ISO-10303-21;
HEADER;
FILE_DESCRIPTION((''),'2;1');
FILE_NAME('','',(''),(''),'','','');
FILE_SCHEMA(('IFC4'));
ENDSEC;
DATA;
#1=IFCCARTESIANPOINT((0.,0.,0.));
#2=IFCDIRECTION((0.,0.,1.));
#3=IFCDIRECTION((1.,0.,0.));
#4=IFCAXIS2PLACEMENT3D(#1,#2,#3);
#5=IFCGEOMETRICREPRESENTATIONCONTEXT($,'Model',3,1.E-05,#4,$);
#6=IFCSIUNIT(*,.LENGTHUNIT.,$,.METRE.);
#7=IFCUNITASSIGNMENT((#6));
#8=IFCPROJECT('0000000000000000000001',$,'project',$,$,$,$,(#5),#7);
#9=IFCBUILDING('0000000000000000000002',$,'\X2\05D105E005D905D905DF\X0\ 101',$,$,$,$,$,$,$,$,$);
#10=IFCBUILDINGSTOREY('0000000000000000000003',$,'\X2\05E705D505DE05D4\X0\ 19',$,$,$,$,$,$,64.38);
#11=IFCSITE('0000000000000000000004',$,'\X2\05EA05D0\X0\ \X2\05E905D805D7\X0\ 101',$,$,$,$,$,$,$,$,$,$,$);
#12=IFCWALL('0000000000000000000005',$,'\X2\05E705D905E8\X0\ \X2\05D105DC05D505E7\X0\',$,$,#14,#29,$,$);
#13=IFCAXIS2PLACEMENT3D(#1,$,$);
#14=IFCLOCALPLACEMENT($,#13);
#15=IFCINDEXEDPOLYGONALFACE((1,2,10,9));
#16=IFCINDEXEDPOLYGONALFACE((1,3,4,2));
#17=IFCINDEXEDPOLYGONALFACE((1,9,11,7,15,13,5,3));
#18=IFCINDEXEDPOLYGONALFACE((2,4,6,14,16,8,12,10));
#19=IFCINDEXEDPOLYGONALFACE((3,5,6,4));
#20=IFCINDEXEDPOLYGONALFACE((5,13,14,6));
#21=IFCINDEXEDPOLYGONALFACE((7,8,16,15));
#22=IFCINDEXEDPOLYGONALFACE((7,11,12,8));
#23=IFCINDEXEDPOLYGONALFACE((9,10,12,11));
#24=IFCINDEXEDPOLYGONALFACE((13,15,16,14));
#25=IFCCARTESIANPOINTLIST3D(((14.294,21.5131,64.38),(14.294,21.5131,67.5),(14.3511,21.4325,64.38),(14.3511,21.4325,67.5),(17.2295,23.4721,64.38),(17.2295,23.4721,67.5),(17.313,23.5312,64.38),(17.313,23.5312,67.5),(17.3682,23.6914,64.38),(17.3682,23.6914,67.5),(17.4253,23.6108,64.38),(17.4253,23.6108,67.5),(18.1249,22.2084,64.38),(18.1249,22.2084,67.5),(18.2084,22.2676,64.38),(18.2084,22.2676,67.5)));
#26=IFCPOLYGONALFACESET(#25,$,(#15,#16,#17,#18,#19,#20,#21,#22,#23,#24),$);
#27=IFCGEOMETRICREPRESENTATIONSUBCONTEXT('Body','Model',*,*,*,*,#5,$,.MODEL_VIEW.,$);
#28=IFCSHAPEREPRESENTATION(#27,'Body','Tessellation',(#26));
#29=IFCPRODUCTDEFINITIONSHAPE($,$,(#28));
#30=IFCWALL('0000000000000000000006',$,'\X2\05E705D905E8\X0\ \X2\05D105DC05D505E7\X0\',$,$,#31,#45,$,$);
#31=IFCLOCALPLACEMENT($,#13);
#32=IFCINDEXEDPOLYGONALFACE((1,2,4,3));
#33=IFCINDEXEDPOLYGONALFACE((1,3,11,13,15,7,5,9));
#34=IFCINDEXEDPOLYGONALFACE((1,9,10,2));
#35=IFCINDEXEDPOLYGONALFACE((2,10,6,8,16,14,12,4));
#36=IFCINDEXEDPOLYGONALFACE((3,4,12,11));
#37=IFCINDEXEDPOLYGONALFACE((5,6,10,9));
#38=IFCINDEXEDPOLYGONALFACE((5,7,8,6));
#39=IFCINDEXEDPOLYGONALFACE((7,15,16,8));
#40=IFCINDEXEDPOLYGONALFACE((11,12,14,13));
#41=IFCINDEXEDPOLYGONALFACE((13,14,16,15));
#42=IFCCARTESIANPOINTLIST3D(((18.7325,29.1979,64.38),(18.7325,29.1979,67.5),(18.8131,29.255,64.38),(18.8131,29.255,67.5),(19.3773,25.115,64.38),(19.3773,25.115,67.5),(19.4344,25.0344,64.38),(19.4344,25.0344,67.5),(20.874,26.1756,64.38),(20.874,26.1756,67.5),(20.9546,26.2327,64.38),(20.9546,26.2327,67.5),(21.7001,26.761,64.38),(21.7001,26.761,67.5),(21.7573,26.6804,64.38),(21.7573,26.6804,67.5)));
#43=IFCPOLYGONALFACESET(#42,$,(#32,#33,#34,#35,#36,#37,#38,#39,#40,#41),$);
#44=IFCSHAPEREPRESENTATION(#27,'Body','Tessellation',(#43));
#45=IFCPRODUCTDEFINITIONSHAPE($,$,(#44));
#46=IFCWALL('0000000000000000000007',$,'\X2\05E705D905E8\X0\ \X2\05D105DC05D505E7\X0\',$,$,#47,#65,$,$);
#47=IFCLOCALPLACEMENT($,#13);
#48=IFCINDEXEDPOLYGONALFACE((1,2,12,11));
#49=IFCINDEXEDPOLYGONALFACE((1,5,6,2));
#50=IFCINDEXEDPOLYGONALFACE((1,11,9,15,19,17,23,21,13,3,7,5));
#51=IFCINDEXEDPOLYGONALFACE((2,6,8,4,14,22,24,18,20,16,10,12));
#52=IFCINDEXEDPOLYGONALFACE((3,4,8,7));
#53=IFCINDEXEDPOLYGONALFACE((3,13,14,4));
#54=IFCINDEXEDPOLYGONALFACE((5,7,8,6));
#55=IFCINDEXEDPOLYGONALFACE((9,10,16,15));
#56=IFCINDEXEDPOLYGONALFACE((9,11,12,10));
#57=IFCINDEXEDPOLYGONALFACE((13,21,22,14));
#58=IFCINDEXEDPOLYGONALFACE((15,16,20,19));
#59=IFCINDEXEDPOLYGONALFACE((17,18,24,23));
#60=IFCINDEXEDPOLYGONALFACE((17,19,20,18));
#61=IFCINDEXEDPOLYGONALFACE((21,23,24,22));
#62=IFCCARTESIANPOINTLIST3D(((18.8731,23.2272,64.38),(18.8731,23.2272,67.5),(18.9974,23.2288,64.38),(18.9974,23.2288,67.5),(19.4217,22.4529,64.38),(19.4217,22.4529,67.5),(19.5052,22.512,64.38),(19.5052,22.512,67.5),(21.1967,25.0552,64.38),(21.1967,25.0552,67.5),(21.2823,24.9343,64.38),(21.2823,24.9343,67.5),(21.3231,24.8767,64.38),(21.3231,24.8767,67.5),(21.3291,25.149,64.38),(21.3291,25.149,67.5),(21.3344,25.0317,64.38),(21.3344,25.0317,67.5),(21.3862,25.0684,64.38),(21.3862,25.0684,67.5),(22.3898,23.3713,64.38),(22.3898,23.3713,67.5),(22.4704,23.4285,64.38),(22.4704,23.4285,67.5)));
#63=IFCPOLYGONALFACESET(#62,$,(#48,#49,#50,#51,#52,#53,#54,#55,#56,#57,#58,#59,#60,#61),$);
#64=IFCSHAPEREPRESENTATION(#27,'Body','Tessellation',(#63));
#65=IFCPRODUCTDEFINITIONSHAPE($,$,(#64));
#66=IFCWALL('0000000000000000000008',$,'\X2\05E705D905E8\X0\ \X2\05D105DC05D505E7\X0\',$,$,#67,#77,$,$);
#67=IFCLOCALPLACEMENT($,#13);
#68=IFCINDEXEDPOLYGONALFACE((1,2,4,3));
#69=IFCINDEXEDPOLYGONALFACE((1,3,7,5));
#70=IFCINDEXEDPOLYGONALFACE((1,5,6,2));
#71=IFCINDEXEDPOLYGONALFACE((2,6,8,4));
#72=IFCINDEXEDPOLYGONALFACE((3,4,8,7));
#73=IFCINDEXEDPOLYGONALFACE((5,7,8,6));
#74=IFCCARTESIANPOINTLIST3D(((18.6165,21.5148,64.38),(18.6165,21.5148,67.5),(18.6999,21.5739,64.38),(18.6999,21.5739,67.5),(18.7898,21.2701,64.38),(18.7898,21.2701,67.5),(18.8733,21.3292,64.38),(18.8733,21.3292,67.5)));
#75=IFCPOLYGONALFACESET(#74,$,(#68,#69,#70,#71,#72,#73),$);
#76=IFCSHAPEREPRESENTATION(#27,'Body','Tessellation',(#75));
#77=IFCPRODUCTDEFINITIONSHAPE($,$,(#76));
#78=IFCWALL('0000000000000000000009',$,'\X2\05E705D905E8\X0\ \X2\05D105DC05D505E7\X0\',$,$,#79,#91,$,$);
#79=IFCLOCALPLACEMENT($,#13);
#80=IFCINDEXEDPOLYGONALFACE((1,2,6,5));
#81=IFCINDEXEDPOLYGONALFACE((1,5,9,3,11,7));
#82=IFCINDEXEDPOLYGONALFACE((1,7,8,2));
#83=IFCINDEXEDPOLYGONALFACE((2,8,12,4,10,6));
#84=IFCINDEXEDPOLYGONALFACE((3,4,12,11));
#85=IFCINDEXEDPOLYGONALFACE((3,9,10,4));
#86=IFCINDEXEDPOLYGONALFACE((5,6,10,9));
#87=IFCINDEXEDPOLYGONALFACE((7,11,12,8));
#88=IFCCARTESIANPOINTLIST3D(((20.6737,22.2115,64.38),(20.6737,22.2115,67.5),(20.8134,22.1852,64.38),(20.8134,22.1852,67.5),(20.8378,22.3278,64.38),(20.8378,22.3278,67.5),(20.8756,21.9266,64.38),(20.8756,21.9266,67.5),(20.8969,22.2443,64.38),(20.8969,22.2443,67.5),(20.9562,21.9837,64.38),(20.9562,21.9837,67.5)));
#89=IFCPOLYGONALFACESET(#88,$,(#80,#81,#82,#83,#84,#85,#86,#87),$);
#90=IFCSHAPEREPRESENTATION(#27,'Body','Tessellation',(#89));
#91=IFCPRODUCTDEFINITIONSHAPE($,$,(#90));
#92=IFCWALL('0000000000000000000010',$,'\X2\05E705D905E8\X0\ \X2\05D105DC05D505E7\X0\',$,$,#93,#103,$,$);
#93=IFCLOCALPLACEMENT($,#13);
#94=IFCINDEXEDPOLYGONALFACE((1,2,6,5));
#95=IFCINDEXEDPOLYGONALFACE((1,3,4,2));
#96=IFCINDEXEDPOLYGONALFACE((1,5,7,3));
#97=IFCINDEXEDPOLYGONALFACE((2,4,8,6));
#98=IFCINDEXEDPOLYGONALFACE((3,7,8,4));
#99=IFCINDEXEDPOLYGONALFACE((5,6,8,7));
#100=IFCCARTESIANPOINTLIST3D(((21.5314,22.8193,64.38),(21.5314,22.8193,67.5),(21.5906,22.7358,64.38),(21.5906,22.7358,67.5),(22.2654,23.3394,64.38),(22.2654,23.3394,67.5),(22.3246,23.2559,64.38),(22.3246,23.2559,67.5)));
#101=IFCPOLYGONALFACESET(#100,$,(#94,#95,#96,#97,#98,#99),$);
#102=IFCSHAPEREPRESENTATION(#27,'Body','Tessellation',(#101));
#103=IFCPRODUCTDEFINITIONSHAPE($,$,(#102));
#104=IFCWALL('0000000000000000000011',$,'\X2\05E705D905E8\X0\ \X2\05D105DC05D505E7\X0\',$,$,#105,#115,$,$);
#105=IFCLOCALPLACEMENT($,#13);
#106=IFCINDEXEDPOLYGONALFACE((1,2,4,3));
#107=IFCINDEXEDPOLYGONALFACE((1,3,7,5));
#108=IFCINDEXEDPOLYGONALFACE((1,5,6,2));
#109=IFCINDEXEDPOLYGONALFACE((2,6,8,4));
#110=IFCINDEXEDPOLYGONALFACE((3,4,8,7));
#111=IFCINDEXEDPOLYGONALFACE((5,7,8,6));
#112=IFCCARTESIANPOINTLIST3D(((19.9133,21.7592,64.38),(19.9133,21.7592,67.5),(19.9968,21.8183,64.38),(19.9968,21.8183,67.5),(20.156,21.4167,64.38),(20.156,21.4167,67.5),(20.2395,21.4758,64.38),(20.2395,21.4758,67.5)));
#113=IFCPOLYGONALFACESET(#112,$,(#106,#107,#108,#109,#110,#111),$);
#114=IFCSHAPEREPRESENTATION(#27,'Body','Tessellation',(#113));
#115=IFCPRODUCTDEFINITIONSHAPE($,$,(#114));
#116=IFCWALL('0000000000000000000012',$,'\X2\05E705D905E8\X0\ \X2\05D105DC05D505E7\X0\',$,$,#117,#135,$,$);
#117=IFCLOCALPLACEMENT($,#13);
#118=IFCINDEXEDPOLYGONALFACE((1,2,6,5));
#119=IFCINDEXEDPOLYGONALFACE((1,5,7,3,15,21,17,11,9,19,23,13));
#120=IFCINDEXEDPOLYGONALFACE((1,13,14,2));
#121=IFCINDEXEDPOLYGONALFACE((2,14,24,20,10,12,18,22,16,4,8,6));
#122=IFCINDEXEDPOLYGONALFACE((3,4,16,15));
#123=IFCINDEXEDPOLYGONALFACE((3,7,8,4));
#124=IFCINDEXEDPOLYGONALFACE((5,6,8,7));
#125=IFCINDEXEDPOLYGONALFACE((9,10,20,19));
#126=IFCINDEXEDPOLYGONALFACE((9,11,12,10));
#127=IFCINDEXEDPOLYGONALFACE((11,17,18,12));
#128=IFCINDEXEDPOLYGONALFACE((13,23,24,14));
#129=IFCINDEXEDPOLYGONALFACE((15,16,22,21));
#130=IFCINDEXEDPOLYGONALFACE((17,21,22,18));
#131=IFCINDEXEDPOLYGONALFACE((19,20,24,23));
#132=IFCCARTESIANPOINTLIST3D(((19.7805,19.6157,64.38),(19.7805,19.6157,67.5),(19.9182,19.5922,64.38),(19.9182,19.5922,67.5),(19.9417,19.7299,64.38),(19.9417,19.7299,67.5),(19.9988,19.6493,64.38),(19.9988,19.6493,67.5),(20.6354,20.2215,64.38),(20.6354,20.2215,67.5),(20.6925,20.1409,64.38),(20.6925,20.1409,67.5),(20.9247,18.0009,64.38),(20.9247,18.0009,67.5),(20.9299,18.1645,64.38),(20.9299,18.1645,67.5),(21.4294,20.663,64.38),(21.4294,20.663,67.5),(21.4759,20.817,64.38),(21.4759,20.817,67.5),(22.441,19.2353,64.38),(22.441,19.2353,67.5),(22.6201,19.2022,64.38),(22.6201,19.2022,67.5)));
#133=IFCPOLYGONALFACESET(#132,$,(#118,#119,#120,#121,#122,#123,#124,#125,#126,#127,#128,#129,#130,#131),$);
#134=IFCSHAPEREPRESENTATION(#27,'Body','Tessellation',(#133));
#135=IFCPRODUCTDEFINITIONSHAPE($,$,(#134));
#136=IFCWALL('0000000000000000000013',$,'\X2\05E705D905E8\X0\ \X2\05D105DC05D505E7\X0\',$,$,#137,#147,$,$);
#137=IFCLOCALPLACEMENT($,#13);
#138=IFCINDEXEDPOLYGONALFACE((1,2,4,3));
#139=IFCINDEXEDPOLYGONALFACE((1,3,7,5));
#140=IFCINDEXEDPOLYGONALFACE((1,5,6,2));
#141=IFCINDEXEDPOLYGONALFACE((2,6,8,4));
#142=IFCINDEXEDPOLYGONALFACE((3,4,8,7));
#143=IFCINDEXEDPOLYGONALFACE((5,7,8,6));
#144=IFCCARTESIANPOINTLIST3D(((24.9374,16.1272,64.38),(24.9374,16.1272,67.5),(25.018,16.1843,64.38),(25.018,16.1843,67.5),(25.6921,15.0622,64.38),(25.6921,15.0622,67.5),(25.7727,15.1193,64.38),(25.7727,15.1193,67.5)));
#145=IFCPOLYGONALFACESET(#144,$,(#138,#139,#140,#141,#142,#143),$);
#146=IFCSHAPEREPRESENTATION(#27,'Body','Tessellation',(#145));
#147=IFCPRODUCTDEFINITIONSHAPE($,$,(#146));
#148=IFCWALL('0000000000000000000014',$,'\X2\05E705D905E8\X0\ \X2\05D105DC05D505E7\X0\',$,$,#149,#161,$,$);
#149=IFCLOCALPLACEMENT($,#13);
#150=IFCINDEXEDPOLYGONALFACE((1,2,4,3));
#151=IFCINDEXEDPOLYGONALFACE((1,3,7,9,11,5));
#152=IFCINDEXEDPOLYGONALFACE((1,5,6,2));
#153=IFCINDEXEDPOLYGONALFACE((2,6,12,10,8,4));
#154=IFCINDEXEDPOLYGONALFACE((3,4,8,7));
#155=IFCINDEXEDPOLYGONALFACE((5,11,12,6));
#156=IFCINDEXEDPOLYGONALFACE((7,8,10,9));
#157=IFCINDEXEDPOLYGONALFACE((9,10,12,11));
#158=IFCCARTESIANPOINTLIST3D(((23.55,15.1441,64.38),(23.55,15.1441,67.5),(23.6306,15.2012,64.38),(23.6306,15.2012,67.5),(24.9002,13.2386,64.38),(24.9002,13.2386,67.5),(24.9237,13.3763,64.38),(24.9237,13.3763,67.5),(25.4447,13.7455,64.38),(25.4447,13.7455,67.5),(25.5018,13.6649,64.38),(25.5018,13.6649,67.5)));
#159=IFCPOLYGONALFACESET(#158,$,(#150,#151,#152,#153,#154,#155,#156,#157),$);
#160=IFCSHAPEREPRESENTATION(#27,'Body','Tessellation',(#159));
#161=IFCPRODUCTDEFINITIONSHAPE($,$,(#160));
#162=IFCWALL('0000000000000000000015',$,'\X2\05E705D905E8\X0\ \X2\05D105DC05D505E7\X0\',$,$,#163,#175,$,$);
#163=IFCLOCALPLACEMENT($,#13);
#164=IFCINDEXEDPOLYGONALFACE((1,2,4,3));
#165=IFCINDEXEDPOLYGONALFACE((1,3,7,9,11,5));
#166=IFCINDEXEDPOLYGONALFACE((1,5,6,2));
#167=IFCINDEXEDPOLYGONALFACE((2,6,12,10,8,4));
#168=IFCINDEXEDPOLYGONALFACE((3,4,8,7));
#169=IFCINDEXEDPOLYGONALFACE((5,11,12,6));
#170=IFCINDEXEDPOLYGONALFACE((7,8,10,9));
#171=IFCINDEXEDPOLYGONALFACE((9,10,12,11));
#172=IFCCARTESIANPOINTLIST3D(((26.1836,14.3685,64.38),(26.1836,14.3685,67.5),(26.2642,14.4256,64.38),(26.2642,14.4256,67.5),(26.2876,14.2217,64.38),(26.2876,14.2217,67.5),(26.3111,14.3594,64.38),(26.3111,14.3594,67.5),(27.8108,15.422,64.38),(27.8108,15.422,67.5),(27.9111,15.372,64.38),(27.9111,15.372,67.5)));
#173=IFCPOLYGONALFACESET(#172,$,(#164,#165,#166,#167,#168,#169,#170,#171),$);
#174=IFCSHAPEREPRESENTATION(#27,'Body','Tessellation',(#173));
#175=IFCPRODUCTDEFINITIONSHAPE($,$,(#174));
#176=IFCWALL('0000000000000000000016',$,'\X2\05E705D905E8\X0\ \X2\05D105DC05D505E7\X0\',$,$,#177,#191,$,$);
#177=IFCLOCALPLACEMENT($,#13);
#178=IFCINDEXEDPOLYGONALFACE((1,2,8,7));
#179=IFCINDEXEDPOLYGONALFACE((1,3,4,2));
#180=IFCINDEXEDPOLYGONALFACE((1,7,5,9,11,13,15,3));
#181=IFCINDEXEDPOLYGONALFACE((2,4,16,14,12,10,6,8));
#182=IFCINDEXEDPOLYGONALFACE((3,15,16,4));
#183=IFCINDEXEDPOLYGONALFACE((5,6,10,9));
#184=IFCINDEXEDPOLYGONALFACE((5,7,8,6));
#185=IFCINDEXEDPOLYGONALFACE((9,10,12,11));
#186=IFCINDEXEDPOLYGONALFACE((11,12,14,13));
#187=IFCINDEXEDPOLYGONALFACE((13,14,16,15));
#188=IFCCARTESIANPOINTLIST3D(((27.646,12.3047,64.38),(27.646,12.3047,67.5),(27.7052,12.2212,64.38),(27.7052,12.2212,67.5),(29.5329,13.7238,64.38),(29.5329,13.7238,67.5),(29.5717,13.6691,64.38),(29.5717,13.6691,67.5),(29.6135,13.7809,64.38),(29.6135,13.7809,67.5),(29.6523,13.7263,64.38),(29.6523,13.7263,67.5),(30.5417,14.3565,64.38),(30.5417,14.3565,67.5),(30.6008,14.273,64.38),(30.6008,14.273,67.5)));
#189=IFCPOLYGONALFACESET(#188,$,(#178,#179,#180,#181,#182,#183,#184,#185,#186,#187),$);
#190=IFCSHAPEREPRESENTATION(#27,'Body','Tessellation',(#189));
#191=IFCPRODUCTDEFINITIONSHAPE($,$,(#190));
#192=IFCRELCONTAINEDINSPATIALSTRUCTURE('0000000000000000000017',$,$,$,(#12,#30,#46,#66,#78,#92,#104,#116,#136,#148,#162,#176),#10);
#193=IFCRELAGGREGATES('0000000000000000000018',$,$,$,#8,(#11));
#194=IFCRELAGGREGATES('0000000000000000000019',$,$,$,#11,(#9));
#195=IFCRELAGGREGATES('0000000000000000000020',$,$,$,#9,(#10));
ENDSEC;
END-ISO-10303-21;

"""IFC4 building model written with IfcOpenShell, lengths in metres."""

from ifc_helpers import new_model, si_unit, frame, origin_with_axes, context, subcontext, project, spatial, polyline, outline, extrude, element, save


model = new_model("IFC4")

# Units and contexts
model_context = context("Model", 3, precision=1e-05, world=origin_with_axes())
body_context = subcontext(model_context, "Body", "Model", "MODEL_VIEW")
ifc_project = project(units=[si_unit("LENGTHUNIT", "METRE")], contexts=[model_context])

# Site, building, storey
site = spatial("IfcSite", under=ifc_project, Name="תא שטח 101")
building = spatial("IfcBuilding", under=site, Name="בניין 101")
storey = spatial("IfcBuildingStorey", under=building, Name="קומה 19", Elevation=64.38)

# Walls
element("IfcWall", 1, inside=storey, Name="קיר בלוק", context=body_context, shape_type="SweptSolid", body=[
    extrude(outline(polyline([(17.2295, 23.4721), (18.1249, 22.2084), (18.2084, 22.2676), (17.313, 23.5312), (17.4253, 23.6108), (17.3682, 23.6914), (14.294, 21.5131), (14.3511, 21.4325), (17.2295, 23.4721)])), frame((0.0, 0.0, 64.38)), (0.0, 0.0, 1.0), 3.12),
])
element("IfcWall", 2, inside=storey, Name="קיר בלוק", context=body_context, shape_type="SweptSolid", body=[
    extrude(outline(polyline([(21.7001, 26.761), (20.9546, 26.2327), (18.8131, 29.255), (18.7325, 29.1979), (20.874, 26.1756), (19.3773, 25.115), (19.4344, 25.0344), (21.7573, 26.6804), (21.7001, 26.761)])), frame((0.0, 0.0, 64.38)), (0.0, 0.0, 1.0), 3.12),
])
element("IfcWall", 3, inside=storey, Name="קיר בלוק", context=body_context, shape_type="SweptSolid", body=[
    extrude(outline(polyline([(22.3898, 23.3713), (22.4704, 23.4285), (21.3344, 25.0317), (21.3862, 25.0684), (21.3291, 25.149), (21.1967, 25.0552), (21.2823, 24.9343), (18.8731, 23.2272), (19.4217, 22.4529), (19.5052, 22.512), (18.9974, 23.2288), (21.3231, 24.8767), (22.3898, 23.3713)])), frame((0.0, 0.0, 64.38)), (0.0, 0.0, 1.0), 3.12),
])
element("IfcWall", 4, inside=storey, Name="קיר בלוק", context=body_context, shape_type="SweptSolid", body=[
    extrude(outline(polyline([(18.6165, 21.5148), (18.7898, 21.2701), (18.8733, 21.3292), (18.6999, 21.5739), (18.6165, 21.5148)])), frame((0.0, 0.0, 64.38)), (0.0, 0.0, 1.0), 3.12),
])
element("IfcWall", 5, inside=storey, Name="קיר בלוק", context=body_context, shape_type="SweptSolid", body=[
    extrude(outline(polyline([(20.6737, 22.2115), (20.8756, 21.9266), (20.9562, 21.9837), (20.8134, 22.1852), (20.8969, 22.2443), (20.8378, 22.3278), (20.6737, 22.2115)])), frame((0.0, 0.0, 64.38)), (0.0, 0.0, 1.0), 3.12),
])
element("IfcWall", 6, inside=storey, Name="קיר בלוק", context=body_context, shape_type="SweptSolid", body=[
    extrude(outline(polyline([(21.5314, 22.8193), (21.5906, 22.7358), (22.3246, 23.2559), (22.2654, 23.3394), (21.5314, 22.8193)])), frame((0.0, 0.0, 64.38)), (0.0, 0.0, 1.0), 3.12),
])
element("IfcWall", 7, inside=storey, Name="קיר בלוק", context=body_context, shape_type="SweptSolid", body=[
    extrude(outline(polyline([(20.2395, 21.4758), (19.9968, 21.8183), (19.9133, 21.7592), (20.156, 21.4167), (20.2395, 21.4758)])), frame((0.0, 0.0, 64.38)), (0.0, 0.0, 1.0), 3.12),
])
element("IfcWall", 8, inside=storey, Name="קיר בלוק", context=body_context, shape_type="SweptSolid", body=[
    extrude(outline(polyline([(22.6201, 19.2022), (21.4759, 20.817), (20.6354, 20.2215), (20.6925, 20.1409), (21.4294, 20.663), (22.441, 19.2353), (20.9299, 18.1645), (19.9182, 19.5922), (19.9988, 19.6493), (19.9417, 19.7299), (19.7805, 19.6157), (20.9247, 18.0009), (22.6201, 19.2022)])), frame((0.0, 0.0, 64.38)), (0.0, 0.0, 1.0), 3.12),
])
element("IfcWall", 9, inside=storey, Name="קיר בלוק", context=body_context, shape_type="SweptSolid", body=[
    extrude(outline(polyline([(25.7727, 15.1193), (25.018, 16.1843), (24.9374, 16.1272), (25.6921, 15.0622), (25.7727, 15.1193)])), frame((0.0, 0.0, 64.38)), (0.0, 0.0, 1.0), 3.12),
])
element("IfcWall", 10, inside=storey, Name="קיר בלוק", context=body_context, shape_type="SweptSolid", body=[
    extrude(outline(polyline([(24.9002, 13.2386), (25.5018, 13.6649), (25.4447, 13.7455), (24.9237, 13.3763), (23.6306, 15.2012), (23.55, 15.1441), (24.9002, 13.2386)])), frame((0.0, 0.0, 64.38)), (0.0, 0.0, 1.0), 3.12),
])
element("IfcWall", 11, inside=storey, Name="קיר בלוק", context=body_context, shape_type="SweptSolid", body=[
    extrude(outline(polyline([(26.2876, 14.2217), (27.9111, 15.372), (27.8108, 15.422), (26.3111, 14.3594), (26.2642, 14.4256), (26.1836, 14.3685), (26.2876, 14.2217)])), frame((0.0, 0.0, 64.38)), (0.0, 0.0, 1.0), 3.12),
])
element("IfcWall", 12, inside=storey, Name="קיר בלוק", context=body_context, shape_type="SweptSolid", body=[
    extrude(outline(polyline([(27.7052, 12.2212), (30.6008, 14.273), (30.5417, 14.3565), (29.6523, 13.7263), (29.6135, 13.7809), (29.5329, 13.7238), (29.5717, 13.6691), (27.646, 12.3047), (27.7052, 12.2212)])), frame((0.0, 0.0, 64.38)), (0.0, 0.0, 1.0), 3.12),
])

save(model, "model.ifc")
